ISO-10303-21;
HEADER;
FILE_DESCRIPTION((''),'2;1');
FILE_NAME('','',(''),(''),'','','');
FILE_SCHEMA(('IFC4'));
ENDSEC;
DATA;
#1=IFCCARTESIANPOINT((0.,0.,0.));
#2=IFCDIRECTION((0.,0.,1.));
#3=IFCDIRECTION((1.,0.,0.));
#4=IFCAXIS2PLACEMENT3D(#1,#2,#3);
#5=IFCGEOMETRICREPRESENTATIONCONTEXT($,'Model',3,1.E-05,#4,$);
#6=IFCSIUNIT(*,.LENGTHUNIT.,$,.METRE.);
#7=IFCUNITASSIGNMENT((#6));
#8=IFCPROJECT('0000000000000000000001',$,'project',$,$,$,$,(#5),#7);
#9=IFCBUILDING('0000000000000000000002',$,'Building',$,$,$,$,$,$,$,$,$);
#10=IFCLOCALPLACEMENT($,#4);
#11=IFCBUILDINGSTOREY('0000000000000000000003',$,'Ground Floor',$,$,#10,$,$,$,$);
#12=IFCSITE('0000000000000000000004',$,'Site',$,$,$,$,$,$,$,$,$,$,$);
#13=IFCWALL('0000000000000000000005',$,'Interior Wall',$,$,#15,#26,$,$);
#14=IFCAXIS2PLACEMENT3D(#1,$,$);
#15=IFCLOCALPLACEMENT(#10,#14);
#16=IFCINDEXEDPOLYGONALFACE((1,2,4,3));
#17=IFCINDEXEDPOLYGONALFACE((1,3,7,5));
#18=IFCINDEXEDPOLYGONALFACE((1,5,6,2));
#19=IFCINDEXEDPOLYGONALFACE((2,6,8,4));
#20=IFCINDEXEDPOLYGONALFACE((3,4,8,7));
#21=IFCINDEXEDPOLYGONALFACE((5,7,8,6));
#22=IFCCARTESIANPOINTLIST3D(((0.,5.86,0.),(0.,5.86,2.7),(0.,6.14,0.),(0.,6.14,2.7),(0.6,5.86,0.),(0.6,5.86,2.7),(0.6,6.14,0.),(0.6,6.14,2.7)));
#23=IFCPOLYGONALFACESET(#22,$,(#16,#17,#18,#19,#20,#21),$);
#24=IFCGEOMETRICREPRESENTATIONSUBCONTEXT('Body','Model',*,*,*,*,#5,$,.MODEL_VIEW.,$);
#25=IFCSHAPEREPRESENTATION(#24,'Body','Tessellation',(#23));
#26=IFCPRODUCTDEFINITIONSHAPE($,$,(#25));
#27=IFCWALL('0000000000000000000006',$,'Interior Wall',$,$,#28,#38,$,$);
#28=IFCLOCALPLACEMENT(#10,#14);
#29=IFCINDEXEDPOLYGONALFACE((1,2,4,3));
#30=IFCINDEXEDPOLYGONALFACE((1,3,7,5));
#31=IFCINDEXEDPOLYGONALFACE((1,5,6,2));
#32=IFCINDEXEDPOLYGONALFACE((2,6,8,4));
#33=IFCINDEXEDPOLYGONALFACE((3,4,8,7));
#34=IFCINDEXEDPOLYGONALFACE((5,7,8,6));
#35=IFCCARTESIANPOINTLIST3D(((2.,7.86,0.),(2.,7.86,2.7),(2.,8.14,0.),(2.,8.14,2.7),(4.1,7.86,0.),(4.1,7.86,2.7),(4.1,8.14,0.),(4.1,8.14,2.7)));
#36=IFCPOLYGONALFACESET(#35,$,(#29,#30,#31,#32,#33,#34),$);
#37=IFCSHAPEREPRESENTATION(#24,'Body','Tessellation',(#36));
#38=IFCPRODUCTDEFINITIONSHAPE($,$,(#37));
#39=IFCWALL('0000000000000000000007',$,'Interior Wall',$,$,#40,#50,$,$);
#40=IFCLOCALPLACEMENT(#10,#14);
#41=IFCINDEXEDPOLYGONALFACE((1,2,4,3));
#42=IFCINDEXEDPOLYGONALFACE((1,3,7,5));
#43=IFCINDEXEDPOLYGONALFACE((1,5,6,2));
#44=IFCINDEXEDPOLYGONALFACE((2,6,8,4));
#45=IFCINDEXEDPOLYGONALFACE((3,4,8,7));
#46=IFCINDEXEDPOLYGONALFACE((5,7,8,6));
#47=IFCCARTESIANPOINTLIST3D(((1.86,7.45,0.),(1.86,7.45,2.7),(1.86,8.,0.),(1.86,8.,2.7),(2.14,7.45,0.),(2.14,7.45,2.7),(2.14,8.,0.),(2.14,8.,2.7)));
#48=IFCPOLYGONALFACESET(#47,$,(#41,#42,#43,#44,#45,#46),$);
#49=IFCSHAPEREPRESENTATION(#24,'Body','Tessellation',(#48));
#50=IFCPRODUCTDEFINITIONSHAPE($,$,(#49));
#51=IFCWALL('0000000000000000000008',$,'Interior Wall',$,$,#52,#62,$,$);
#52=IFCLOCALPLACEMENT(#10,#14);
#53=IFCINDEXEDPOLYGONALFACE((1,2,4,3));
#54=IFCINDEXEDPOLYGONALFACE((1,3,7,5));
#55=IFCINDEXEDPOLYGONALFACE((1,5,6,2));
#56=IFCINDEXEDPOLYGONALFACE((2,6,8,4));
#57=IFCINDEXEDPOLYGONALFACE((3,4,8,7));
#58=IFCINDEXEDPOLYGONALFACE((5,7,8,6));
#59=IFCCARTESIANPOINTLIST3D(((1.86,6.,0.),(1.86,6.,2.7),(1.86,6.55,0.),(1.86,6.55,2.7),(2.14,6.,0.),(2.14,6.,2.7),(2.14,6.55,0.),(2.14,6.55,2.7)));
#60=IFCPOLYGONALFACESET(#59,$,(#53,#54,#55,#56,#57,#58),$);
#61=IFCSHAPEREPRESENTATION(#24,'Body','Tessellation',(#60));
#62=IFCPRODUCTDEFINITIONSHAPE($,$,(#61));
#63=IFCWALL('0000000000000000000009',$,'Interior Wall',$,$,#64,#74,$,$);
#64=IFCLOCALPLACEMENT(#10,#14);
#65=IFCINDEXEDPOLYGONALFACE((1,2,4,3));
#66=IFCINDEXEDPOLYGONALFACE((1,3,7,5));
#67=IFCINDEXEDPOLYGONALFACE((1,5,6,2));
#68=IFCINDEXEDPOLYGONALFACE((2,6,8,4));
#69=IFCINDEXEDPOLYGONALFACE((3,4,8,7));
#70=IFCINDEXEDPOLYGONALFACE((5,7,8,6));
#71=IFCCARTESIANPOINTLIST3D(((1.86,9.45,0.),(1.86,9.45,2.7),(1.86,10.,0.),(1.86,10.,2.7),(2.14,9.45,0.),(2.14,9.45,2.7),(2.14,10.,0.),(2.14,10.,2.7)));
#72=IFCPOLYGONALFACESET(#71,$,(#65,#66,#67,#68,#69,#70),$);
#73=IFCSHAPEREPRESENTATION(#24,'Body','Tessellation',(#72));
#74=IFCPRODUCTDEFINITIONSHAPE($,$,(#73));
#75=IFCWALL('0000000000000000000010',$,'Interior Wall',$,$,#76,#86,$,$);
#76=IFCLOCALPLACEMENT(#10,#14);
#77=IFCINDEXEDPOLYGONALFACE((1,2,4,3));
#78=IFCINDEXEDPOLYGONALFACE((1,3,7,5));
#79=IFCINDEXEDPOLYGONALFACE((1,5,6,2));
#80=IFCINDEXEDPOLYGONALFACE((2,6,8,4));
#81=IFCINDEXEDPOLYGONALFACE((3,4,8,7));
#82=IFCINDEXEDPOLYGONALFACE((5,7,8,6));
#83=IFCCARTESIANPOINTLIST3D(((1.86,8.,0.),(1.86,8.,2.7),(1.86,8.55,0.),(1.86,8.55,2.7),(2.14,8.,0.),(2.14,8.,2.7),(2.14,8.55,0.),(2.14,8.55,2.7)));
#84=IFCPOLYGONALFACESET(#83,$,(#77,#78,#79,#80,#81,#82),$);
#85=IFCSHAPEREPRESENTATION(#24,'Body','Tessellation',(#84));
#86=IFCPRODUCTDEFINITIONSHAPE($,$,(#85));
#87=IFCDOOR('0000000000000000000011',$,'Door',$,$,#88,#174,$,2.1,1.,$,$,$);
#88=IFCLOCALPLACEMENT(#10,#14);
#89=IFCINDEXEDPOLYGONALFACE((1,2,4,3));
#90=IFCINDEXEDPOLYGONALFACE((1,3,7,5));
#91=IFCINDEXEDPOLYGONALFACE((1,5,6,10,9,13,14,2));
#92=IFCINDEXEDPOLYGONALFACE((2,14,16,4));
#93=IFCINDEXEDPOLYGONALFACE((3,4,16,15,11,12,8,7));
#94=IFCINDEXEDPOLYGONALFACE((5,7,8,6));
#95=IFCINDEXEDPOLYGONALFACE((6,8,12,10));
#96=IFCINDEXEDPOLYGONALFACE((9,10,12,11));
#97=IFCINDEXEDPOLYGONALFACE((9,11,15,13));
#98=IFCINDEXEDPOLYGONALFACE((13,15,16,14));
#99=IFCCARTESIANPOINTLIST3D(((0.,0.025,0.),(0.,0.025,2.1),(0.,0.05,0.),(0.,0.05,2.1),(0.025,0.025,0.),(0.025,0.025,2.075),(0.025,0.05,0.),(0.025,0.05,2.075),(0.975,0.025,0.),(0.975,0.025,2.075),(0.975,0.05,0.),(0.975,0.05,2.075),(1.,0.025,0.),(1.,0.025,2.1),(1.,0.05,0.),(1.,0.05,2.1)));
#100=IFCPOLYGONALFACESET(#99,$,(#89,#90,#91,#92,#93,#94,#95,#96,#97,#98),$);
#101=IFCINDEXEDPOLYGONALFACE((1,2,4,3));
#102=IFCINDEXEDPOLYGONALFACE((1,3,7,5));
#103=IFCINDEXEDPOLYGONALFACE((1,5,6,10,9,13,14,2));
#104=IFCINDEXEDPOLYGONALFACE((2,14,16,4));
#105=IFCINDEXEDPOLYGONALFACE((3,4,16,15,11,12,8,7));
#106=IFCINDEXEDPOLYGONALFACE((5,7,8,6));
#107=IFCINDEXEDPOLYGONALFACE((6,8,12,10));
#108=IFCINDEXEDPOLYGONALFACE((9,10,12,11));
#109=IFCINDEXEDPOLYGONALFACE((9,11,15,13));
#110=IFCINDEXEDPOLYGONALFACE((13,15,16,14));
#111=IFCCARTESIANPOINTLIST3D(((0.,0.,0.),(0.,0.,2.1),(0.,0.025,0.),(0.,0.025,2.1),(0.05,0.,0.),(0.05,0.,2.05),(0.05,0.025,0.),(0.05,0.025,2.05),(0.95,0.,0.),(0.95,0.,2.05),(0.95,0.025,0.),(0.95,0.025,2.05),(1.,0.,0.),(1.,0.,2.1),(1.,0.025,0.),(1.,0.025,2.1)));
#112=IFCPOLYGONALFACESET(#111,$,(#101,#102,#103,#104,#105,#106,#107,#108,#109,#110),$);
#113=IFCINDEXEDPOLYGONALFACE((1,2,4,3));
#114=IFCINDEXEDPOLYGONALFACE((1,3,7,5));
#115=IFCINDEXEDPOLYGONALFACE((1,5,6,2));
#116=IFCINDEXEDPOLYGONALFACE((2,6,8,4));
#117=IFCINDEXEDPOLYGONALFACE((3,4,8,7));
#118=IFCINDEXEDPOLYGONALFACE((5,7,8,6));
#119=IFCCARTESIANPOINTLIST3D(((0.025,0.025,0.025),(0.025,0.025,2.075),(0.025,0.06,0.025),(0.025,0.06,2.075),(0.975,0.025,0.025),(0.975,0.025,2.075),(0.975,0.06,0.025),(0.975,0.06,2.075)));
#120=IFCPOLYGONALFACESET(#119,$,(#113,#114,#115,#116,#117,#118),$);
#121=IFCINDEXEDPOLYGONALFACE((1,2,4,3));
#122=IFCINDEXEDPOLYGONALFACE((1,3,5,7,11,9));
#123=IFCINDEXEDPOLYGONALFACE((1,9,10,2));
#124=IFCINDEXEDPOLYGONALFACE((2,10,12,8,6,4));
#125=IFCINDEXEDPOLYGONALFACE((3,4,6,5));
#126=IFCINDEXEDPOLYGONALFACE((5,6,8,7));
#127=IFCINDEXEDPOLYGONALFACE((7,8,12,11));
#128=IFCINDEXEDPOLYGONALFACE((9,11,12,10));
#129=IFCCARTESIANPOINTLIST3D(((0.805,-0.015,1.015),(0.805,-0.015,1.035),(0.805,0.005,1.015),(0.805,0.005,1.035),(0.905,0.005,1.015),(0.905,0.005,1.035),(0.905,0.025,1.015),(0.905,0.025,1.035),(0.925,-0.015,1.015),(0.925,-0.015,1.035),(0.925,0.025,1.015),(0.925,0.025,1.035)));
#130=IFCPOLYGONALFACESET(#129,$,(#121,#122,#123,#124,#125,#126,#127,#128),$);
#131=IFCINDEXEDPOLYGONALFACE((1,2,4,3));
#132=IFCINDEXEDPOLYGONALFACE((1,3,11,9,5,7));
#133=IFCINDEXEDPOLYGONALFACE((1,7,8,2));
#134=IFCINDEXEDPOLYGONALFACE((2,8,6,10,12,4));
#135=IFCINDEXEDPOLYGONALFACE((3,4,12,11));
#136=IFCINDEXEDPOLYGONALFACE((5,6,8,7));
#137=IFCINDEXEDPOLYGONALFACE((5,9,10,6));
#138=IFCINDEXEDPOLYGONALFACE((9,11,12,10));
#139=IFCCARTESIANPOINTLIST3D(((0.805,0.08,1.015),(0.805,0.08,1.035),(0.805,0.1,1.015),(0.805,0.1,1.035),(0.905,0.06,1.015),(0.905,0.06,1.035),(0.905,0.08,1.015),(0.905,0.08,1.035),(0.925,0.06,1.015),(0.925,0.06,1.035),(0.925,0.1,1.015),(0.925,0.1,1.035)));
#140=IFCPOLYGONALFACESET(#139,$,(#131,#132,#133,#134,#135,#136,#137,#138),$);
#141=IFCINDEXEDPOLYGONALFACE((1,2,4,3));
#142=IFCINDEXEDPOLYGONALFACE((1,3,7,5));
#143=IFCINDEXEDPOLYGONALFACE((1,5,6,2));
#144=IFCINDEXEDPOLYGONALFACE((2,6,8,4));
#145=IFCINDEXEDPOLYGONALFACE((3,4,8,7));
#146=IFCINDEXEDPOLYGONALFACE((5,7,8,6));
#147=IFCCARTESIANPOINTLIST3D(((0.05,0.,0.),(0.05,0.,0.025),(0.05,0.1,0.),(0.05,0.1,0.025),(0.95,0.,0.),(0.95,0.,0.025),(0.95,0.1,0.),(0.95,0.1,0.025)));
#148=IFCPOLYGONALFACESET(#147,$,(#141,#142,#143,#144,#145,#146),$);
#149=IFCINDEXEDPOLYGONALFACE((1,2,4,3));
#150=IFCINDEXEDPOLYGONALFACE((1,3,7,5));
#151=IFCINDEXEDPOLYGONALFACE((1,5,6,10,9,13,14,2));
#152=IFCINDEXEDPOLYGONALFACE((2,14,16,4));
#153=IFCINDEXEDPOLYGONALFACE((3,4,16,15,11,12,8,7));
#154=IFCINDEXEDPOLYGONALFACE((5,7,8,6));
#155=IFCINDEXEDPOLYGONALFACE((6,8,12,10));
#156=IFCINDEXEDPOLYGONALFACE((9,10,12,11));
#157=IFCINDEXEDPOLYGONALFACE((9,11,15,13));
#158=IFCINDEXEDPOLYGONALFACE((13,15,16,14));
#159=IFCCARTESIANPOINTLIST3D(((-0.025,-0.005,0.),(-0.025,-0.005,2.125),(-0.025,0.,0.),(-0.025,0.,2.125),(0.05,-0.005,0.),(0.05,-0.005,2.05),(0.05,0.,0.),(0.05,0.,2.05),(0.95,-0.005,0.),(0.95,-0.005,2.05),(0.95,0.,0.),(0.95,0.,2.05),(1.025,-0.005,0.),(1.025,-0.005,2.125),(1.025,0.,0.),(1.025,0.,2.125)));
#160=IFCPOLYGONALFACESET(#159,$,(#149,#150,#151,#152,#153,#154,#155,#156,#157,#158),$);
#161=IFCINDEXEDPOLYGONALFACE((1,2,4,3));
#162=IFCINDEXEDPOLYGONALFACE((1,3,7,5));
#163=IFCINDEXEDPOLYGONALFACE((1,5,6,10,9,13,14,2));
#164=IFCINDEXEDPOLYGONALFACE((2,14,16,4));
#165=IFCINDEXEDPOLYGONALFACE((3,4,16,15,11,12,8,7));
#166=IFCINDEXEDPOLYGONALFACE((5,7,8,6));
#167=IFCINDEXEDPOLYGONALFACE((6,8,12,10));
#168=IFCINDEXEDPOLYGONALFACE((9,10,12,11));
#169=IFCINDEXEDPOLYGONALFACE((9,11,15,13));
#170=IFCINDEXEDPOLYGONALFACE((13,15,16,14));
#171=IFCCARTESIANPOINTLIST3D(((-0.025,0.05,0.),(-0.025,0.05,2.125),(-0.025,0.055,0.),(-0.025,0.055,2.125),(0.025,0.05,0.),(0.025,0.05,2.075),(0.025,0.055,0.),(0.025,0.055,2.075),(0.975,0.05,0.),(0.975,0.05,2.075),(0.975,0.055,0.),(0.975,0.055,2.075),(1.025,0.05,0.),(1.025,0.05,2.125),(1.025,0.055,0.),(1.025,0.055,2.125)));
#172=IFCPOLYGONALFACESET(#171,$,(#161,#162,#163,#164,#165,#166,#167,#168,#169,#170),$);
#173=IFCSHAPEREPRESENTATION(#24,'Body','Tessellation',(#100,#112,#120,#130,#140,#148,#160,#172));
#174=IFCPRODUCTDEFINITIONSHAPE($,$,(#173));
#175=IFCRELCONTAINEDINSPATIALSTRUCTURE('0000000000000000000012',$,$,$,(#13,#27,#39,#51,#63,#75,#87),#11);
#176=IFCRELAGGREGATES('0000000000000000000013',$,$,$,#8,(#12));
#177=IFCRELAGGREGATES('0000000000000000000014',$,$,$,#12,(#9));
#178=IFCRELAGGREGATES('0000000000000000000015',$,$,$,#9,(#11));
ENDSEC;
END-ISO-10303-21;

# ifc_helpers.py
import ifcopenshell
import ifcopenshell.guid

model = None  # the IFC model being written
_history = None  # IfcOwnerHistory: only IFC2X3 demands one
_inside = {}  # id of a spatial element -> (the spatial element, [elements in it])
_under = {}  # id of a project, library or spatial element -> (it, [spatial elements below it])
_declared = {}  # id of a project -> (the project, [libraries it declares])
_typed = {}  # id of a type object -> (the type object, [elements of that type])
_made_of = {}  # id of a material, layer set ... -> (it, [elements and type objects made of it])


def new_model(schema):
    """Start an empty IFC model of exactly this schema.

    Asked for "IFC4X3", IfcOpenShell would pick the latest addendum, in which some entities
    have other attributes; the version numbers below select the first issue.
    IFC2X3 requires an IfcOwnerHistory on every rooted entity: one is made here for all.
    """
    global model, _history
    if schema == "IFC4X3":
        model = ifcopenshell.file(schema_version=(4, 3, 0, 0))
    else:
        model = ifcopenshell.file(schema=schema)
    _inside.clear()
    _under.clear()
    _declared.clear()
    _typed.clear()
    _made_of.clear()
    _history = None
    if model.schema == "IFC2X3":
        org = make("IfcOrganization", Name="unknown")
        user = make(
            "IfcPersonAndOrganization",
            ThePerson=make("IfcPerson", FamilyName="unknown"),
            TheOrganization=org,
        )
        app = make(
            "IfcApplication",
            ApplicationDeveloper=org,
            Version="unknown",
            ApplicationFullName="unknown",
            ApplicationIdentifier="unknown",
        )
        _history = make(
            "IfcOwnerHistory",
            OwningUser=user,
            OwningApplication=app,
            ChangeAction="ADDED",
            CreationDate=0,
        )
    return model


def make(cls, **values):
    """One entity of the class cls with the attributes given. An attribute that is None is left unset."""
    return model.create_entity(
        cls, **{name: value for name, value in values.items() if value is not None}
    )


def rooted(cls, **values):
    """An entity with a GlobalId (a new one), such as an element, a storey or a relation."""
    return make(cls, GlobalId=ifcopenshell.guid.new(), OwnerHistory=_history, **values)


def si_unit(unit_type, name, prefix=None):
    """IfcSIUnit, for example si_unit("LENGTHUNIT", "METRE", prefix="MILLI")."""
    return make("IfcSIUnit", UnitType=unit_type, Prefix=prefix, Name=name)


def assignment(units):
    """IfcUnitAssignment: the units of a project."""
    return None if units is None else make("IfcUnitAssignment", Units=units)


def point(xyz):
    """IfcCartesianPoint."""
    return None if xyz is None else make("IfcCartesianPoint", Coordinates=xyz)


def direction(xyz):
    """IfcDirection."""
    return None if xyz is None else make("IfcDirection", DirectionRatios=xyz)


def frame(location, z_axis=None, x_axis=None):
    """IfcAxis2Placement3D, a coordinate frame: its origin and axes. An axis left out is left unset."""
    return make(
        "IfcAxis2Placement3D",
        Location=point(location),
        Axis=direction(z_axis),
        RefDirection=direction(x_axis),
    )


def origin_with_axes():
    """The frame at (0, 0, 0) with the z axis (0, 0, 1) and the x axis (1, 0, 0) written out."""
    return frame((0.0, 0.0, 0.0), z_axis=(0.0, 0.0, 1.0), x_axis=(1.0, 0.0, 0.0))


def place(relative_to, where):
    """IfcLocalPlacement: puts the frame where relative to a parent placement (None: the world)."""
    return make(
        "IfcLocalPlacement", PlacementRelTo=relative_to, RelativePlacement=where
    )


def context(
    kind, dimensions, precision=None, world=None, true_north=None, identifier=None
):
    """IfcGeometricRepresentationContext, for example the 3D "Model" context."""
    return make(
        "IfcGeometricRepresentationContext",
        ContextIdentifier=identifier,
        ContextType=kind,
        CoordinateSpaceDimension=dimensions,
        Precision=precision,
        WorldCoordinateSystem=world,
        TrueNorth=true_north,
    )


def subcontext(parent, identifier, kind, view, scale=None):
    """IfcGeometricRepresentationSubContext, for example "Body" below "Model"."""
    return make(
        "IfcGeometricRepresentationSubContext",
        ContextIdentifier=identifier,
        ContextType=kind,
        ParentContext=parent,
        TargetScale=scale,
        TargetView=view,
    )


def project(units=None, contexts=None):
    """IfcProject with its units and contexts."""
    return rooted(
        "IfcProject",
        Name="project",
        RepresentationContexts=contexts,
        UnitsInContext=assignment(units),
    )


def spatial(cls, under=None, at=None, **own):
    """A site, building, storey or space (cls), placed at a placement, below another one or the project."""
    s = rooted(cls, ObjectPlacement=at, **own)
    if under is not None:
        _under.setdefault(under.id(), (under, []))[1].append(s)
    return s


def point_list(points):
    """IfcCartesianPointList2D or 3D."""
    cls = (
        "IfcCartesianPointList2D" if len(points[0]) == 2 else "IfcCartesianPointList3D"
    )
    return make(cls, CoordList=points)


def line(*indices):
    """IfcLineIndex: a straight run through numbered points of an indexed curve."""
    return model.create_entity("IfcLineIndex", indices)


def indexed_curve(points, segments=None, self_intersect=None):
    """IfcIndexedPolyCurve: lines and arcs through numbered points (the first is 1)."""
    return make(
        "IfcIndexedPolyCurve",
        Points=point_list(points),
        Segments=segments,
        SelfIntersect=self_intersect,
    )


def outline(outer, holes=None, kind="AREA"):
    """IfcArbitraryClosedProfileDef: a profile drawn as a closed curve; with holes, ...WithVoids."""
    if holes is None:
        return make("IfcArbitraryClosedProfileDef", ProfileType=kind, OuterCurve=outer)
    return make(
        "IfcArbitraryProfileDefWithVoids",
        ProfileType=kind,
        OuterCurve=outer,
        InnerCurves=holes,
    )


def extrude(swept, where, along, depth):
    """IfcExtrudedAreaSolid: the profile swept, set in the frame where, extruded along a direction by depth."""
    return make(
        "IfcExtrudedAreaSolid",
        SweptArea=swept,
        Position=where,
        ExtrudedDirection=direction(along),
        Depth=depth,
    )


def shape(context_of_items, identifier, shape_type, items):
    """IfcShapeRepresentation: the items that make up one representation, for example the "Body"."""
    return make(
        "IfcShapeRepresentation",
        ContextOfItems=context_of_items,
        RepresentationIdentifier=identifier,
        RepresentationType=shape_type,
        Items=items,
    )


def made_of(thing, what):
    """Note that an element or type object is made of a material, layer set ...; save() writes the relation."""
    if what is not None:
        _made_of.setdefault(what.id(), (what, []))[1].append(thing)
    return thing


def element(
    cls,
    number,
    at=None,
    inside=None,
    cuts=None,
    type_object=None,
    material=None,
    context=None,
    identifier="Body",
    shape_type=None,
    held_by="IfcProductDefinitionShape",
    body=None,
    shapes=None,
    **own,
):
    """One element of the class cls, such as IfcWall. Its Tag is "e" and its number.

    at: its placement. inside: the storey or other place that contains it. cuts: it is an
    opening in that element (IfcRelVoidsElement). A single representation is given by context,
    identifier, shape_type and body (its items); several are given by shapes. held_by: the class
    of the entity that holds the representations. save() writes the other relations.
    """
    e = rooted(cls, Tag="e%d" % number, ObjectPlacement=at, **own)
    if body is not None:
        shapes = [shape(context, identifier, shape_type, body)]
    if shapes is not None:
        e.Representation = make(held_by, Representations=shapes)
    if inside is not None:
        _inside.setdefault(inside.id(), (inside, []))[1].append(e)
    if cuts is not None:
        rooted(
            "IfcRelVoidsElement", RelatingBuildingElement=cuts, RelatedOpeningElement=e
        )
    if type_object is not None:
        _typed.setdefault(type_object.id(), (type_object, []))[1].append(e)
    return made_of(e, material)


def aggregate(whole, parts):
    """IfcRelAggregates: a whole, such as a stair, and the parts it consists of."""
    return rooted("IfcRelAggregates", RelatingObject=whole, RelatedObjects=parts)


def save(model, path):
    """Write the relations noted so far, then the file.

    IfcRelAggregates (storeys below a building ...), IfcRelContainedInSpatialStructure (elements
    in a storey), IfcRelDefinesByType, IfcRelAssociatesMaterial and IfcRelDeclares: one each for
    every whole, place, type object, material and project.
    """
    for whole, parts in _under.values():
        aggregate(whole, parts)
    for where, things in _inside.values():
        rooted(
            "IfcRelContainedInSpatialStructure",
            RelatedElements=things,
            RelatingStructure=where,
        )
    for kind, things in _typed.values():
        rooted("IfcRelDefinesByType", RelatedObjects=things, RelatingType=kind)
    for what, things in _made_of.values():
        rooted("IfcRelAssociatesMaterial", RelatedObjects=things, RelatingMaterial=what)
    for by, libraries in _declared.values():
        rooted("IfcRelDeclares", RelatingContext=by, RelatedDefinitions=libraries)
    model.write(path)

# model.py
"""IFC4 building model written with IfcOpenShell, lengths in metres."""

from ifc_helpers import new_model, si_unit, frame, origin_with_axes, place, context, subcontext, project, spatial, line, indexed_curve, outline, extrude, element, save


model = new_model("IFC4")

# Units and contexts
model_context = context("Model", 3, precision=1e-05, world=origin_with_axes())
body_context = subcontext(model_context, "Body", "Model", "MODEL_VIEW")
ifc_project = project(units=[si_unit("LENGTHUNIT", "METRE")], contexts=[model_context])

# Site, building, storey
site = spatial("IfcSite", under=ifc_project, Name="Site")
building = spatial("IfcBuilding", under=site, Name="Building")
storey_placement = place(None, origin_with_axes())
storey = spatial("IfcBuildingStorey", under=building, at=storey_placement, Name="Ground Floor")

# Walls
for number, where, z_axis, x_axis, name in (
    (1, (0.6, 6.0, 0.0), (0.0, 0.0, 1.0), (-1.0, 0.0, 0.0), "Interior Wall"),
):
    element("IfcWall", number, at=place(storey_placement, frame(where, z_axis=z_axis, x_axis=x_axis)), inside=storey, Name=name, context=body_context, shape_type="SweptSolid", body=[
        extrude(outline(indexed_curve([(0.0, 0.0), (0.0, 0.28), (0.6, 0.28), (0.6, 0.0), (0.0, 0.0)], self_intersect=False)), frame((0.0, -0.14, 0.0), z_axis=(0.0, 0.0, 1.0), x_axis=(1.0, 0.0, 0.0)), (0.0, 0.0, 1.0), 2.7),
    ])
wall_1_placement = place(storey_placement, frame((4.1, 8.0, 0.0), z_axis=(0.0, 0.0, 1.0), x_axis=(-1.0, 0.0, 0.0)))
element("IfcWall", 2, at=wall_1_placement, inside=storey, Name="Interior Wall", context=body_context, shape_type="SweptSolid", body=[
    extrude(outline(indexed_curve([(0.0, 0.0), (0.0, 0.28), (2.1, 0.28), (2.1, 0.0), (0.0, 0.0)], self_intersect=False)), frame((0.0, -0.14, 0.0), z_axis=(0.0, 0.0, 1.0), x_axis=(1.0, 0.0, 0.0)), (0.0, 0.0, 1.0), 2.7),
])
for number, where, z_axis, x_axis, name in (
    (3, (2.0, 8.0, 0.0), (0.0, 0.0, 1.0), (0.0, -1.0, 0.0), "Interior Wall"),
    (4, (2.0, 6.55, 0.0), (0.0, 0.0, 1.0), (0.0, -1.0, 0.0), "Interior Wall"),
):
    element("IfcWall", number, at=place(storey_placement, frame(where, z_axis=z_axis, x_axis=x_axis)), inside=storey, Name=name, context=body_context, shape_type="SweptSolid", body=[
        extrude(outline(indexed_curve([(0.0, 0.0), (0.0, 0.28), (0.55, 0.28), (0.55, 0.0), (0.0, 0.0)], self_intersect=False)), frame((0.0, -0.14, 0.0), z_axis=(0.0, 0.0, 1.0), x_axis=(1.0, 0.0, 0.0)), (0.0, 0.0, 1.0), 2.7),
    ])
for number, where, z_axis, x_axis, name in (
    (5, (2.0, 10.0, 0.0), (0.0, 0.0, 1.0), (0.0, -1.0, 0.0), "Interior Wall"),
    (6, (2.0, 8.55, 0.0), (0.0, 0.0, 1.0), (0.0, -1.0, 0.0), "Interior Wall"),
):
    element("IfcWall", number, at=place(storey_placement, frame(where, z_axis=z_axis, x_axis=x_axis)), inside=storey, Name=name, context=body_context, shape_type="SweptSolid", body=[
        extrude(outline(indexed_curve([(0.0, 0.0), (0.0, 0.28), (0.55, 0.28), (0.55, 0.0), (0.0, 0.0)], self_intersect=False)), frame((0.0, -0.14, 0.0), z_axis=(0.0, 0.0, 1.0), x_axis=(1.0, 0.0, 0.0)), (0.0, 0.0, 1.0), 2.7),
    ])

# Door
door_1_placement = place(storey_placement, origin_with_axes())
element("IfcDoor", 7, at=door_1_placement, inside=storey, Name="Door", OverallHeight=2.1, OverallWidth=1.0, context=body_context, shape_type="SweptSolid", body=[
    extrude(outline(indexed_curve([(0.0, 0.0), (0.0, 2.1), (1.0, 2.1), (1.0, 0.0), (0.975, 0.0), (0.975, 2.075), (0.025, 2.075), (0.025, 0.0)], segments=[line(1, 2, 3, 4, 5, 6, 7, 8, 1)])), frame((0.0, 0.025, 0.0), z_axis=(0.0, -1.0, 0.0), x_axis=(1.0, 0.0, 0.0)), (0.0, 0.0, -1.0), 0.025),
    extrude(outline(indexed_curve([(0.0, 0.0), (0.0, 2.1), (1.0, 2.1), (1.0, 0.0), (0.95, 0.0), (0.95, 2.05), (0.05, 2.05), (0.05, 0.0)], segments=[line(1, 2, 3, 4, 5, 6, 7, 8, 1)])), frame((0.0, 0.0, 0.0), z_axis=(0.0, -1.0, 0.0), x_axis=(1.0, 0.0, 0.0)), (0.0, 0.0, -1.0), 0.025),
    extrude(outline(indexed_curve([(0.0, 0.0), (0.95, 0.0), (0.95, 0.035), (0.0, 0.035)], segments=[line(1, 2, 3, 4, 1)])), frame((0.025, 0.025, 0.025), z_axis=(0.0, 0.0, 1.0), x_axis=(1.0, 0.0, 0.0)), (0.0, 0.0, 1.0), 2.05),
    extrude(outline(indexed_curve([(0.0, 0.0), (0.0, -0.04), (-0.12, -0.04), (-0.12, -0.02), (-0.02, -0.02), (-0.02, 0.0)], segments=[line(1, 2, 3, 4, 5, 6, 1)])), frame((0.925, 0.025, 1.015), z_axis=(0.0, 0.0, 1.0), x_axis=(1.0, 0.0, 0.0)), (0.0, 0.0, 1.0), 0.02),
    extrude(outline(indexed_curve([(0.0, 0.0), (0.0, 0.04), (-0.12, 0.04), (-0.12, 0.02), (-0.02, 0.02), (-0.02, 0.0)], segments=[line(1, 2, 3, 4, 5, 6, 1)])), frame((0.925, 0.06, 1.015), z_axis=(0.0, 0.0, 1.0), x_axis=(1.0, 0.0, 0.0)), (0.0, 0.0, 1.0), 0.02),
    extrude(outline(indexed_curve([(0.0, 0.0), (0.9, 0.0), (0.9, 0.1), (0.0, 0.1)], segments=[line(1, 2, 3, 4, 1)])), frame((0.05, 0.0, 0.0), z_axis=(0.0, 0.0, 1.0), x_axis=(1.0, 0.0, 0.0)), (0.0, 0.0, 1.0), 0.025),
    extrude(outline(indexed_curve([(0.0, 0.0), (0.0, 2.125), (1.05, 2.125), (1.05, 0.0), (0.975, 0.0), (0.975, 2.05), (0.075, 2.05), (0.075, 0.0)], segments=[line(1, 2, 3, 4, 5, 6, 7, 8, 1)])), frame((-0.025, -0.005, 0.0), z_axis=(0.0, -1.0, 0.0), x_axis=(1.0, 0.0, 0.0)), (0.0, 0.0, -1.0), 0.005),
    extrude(outline(indexed_curve([(0.0, 0.0), (0.0, 2.125), (1.05, 2.125), (1.05, 0.0), (1.0, 0.0), (1.0, 2.075), (0.05, 2.075), (0.05, 0.0)], segments=[line(1, 2, 3, 4, 5, 6, 7, 8, 1)])), frame((-0.025, 0.05, 0.0), z_axis=(0.0, -1.0, 0.0), x_axis=(1.0, 0.0, 0.0)), (0.0, 0.0, -1.0), 0.005),
])

save(model, "model.ifc")
